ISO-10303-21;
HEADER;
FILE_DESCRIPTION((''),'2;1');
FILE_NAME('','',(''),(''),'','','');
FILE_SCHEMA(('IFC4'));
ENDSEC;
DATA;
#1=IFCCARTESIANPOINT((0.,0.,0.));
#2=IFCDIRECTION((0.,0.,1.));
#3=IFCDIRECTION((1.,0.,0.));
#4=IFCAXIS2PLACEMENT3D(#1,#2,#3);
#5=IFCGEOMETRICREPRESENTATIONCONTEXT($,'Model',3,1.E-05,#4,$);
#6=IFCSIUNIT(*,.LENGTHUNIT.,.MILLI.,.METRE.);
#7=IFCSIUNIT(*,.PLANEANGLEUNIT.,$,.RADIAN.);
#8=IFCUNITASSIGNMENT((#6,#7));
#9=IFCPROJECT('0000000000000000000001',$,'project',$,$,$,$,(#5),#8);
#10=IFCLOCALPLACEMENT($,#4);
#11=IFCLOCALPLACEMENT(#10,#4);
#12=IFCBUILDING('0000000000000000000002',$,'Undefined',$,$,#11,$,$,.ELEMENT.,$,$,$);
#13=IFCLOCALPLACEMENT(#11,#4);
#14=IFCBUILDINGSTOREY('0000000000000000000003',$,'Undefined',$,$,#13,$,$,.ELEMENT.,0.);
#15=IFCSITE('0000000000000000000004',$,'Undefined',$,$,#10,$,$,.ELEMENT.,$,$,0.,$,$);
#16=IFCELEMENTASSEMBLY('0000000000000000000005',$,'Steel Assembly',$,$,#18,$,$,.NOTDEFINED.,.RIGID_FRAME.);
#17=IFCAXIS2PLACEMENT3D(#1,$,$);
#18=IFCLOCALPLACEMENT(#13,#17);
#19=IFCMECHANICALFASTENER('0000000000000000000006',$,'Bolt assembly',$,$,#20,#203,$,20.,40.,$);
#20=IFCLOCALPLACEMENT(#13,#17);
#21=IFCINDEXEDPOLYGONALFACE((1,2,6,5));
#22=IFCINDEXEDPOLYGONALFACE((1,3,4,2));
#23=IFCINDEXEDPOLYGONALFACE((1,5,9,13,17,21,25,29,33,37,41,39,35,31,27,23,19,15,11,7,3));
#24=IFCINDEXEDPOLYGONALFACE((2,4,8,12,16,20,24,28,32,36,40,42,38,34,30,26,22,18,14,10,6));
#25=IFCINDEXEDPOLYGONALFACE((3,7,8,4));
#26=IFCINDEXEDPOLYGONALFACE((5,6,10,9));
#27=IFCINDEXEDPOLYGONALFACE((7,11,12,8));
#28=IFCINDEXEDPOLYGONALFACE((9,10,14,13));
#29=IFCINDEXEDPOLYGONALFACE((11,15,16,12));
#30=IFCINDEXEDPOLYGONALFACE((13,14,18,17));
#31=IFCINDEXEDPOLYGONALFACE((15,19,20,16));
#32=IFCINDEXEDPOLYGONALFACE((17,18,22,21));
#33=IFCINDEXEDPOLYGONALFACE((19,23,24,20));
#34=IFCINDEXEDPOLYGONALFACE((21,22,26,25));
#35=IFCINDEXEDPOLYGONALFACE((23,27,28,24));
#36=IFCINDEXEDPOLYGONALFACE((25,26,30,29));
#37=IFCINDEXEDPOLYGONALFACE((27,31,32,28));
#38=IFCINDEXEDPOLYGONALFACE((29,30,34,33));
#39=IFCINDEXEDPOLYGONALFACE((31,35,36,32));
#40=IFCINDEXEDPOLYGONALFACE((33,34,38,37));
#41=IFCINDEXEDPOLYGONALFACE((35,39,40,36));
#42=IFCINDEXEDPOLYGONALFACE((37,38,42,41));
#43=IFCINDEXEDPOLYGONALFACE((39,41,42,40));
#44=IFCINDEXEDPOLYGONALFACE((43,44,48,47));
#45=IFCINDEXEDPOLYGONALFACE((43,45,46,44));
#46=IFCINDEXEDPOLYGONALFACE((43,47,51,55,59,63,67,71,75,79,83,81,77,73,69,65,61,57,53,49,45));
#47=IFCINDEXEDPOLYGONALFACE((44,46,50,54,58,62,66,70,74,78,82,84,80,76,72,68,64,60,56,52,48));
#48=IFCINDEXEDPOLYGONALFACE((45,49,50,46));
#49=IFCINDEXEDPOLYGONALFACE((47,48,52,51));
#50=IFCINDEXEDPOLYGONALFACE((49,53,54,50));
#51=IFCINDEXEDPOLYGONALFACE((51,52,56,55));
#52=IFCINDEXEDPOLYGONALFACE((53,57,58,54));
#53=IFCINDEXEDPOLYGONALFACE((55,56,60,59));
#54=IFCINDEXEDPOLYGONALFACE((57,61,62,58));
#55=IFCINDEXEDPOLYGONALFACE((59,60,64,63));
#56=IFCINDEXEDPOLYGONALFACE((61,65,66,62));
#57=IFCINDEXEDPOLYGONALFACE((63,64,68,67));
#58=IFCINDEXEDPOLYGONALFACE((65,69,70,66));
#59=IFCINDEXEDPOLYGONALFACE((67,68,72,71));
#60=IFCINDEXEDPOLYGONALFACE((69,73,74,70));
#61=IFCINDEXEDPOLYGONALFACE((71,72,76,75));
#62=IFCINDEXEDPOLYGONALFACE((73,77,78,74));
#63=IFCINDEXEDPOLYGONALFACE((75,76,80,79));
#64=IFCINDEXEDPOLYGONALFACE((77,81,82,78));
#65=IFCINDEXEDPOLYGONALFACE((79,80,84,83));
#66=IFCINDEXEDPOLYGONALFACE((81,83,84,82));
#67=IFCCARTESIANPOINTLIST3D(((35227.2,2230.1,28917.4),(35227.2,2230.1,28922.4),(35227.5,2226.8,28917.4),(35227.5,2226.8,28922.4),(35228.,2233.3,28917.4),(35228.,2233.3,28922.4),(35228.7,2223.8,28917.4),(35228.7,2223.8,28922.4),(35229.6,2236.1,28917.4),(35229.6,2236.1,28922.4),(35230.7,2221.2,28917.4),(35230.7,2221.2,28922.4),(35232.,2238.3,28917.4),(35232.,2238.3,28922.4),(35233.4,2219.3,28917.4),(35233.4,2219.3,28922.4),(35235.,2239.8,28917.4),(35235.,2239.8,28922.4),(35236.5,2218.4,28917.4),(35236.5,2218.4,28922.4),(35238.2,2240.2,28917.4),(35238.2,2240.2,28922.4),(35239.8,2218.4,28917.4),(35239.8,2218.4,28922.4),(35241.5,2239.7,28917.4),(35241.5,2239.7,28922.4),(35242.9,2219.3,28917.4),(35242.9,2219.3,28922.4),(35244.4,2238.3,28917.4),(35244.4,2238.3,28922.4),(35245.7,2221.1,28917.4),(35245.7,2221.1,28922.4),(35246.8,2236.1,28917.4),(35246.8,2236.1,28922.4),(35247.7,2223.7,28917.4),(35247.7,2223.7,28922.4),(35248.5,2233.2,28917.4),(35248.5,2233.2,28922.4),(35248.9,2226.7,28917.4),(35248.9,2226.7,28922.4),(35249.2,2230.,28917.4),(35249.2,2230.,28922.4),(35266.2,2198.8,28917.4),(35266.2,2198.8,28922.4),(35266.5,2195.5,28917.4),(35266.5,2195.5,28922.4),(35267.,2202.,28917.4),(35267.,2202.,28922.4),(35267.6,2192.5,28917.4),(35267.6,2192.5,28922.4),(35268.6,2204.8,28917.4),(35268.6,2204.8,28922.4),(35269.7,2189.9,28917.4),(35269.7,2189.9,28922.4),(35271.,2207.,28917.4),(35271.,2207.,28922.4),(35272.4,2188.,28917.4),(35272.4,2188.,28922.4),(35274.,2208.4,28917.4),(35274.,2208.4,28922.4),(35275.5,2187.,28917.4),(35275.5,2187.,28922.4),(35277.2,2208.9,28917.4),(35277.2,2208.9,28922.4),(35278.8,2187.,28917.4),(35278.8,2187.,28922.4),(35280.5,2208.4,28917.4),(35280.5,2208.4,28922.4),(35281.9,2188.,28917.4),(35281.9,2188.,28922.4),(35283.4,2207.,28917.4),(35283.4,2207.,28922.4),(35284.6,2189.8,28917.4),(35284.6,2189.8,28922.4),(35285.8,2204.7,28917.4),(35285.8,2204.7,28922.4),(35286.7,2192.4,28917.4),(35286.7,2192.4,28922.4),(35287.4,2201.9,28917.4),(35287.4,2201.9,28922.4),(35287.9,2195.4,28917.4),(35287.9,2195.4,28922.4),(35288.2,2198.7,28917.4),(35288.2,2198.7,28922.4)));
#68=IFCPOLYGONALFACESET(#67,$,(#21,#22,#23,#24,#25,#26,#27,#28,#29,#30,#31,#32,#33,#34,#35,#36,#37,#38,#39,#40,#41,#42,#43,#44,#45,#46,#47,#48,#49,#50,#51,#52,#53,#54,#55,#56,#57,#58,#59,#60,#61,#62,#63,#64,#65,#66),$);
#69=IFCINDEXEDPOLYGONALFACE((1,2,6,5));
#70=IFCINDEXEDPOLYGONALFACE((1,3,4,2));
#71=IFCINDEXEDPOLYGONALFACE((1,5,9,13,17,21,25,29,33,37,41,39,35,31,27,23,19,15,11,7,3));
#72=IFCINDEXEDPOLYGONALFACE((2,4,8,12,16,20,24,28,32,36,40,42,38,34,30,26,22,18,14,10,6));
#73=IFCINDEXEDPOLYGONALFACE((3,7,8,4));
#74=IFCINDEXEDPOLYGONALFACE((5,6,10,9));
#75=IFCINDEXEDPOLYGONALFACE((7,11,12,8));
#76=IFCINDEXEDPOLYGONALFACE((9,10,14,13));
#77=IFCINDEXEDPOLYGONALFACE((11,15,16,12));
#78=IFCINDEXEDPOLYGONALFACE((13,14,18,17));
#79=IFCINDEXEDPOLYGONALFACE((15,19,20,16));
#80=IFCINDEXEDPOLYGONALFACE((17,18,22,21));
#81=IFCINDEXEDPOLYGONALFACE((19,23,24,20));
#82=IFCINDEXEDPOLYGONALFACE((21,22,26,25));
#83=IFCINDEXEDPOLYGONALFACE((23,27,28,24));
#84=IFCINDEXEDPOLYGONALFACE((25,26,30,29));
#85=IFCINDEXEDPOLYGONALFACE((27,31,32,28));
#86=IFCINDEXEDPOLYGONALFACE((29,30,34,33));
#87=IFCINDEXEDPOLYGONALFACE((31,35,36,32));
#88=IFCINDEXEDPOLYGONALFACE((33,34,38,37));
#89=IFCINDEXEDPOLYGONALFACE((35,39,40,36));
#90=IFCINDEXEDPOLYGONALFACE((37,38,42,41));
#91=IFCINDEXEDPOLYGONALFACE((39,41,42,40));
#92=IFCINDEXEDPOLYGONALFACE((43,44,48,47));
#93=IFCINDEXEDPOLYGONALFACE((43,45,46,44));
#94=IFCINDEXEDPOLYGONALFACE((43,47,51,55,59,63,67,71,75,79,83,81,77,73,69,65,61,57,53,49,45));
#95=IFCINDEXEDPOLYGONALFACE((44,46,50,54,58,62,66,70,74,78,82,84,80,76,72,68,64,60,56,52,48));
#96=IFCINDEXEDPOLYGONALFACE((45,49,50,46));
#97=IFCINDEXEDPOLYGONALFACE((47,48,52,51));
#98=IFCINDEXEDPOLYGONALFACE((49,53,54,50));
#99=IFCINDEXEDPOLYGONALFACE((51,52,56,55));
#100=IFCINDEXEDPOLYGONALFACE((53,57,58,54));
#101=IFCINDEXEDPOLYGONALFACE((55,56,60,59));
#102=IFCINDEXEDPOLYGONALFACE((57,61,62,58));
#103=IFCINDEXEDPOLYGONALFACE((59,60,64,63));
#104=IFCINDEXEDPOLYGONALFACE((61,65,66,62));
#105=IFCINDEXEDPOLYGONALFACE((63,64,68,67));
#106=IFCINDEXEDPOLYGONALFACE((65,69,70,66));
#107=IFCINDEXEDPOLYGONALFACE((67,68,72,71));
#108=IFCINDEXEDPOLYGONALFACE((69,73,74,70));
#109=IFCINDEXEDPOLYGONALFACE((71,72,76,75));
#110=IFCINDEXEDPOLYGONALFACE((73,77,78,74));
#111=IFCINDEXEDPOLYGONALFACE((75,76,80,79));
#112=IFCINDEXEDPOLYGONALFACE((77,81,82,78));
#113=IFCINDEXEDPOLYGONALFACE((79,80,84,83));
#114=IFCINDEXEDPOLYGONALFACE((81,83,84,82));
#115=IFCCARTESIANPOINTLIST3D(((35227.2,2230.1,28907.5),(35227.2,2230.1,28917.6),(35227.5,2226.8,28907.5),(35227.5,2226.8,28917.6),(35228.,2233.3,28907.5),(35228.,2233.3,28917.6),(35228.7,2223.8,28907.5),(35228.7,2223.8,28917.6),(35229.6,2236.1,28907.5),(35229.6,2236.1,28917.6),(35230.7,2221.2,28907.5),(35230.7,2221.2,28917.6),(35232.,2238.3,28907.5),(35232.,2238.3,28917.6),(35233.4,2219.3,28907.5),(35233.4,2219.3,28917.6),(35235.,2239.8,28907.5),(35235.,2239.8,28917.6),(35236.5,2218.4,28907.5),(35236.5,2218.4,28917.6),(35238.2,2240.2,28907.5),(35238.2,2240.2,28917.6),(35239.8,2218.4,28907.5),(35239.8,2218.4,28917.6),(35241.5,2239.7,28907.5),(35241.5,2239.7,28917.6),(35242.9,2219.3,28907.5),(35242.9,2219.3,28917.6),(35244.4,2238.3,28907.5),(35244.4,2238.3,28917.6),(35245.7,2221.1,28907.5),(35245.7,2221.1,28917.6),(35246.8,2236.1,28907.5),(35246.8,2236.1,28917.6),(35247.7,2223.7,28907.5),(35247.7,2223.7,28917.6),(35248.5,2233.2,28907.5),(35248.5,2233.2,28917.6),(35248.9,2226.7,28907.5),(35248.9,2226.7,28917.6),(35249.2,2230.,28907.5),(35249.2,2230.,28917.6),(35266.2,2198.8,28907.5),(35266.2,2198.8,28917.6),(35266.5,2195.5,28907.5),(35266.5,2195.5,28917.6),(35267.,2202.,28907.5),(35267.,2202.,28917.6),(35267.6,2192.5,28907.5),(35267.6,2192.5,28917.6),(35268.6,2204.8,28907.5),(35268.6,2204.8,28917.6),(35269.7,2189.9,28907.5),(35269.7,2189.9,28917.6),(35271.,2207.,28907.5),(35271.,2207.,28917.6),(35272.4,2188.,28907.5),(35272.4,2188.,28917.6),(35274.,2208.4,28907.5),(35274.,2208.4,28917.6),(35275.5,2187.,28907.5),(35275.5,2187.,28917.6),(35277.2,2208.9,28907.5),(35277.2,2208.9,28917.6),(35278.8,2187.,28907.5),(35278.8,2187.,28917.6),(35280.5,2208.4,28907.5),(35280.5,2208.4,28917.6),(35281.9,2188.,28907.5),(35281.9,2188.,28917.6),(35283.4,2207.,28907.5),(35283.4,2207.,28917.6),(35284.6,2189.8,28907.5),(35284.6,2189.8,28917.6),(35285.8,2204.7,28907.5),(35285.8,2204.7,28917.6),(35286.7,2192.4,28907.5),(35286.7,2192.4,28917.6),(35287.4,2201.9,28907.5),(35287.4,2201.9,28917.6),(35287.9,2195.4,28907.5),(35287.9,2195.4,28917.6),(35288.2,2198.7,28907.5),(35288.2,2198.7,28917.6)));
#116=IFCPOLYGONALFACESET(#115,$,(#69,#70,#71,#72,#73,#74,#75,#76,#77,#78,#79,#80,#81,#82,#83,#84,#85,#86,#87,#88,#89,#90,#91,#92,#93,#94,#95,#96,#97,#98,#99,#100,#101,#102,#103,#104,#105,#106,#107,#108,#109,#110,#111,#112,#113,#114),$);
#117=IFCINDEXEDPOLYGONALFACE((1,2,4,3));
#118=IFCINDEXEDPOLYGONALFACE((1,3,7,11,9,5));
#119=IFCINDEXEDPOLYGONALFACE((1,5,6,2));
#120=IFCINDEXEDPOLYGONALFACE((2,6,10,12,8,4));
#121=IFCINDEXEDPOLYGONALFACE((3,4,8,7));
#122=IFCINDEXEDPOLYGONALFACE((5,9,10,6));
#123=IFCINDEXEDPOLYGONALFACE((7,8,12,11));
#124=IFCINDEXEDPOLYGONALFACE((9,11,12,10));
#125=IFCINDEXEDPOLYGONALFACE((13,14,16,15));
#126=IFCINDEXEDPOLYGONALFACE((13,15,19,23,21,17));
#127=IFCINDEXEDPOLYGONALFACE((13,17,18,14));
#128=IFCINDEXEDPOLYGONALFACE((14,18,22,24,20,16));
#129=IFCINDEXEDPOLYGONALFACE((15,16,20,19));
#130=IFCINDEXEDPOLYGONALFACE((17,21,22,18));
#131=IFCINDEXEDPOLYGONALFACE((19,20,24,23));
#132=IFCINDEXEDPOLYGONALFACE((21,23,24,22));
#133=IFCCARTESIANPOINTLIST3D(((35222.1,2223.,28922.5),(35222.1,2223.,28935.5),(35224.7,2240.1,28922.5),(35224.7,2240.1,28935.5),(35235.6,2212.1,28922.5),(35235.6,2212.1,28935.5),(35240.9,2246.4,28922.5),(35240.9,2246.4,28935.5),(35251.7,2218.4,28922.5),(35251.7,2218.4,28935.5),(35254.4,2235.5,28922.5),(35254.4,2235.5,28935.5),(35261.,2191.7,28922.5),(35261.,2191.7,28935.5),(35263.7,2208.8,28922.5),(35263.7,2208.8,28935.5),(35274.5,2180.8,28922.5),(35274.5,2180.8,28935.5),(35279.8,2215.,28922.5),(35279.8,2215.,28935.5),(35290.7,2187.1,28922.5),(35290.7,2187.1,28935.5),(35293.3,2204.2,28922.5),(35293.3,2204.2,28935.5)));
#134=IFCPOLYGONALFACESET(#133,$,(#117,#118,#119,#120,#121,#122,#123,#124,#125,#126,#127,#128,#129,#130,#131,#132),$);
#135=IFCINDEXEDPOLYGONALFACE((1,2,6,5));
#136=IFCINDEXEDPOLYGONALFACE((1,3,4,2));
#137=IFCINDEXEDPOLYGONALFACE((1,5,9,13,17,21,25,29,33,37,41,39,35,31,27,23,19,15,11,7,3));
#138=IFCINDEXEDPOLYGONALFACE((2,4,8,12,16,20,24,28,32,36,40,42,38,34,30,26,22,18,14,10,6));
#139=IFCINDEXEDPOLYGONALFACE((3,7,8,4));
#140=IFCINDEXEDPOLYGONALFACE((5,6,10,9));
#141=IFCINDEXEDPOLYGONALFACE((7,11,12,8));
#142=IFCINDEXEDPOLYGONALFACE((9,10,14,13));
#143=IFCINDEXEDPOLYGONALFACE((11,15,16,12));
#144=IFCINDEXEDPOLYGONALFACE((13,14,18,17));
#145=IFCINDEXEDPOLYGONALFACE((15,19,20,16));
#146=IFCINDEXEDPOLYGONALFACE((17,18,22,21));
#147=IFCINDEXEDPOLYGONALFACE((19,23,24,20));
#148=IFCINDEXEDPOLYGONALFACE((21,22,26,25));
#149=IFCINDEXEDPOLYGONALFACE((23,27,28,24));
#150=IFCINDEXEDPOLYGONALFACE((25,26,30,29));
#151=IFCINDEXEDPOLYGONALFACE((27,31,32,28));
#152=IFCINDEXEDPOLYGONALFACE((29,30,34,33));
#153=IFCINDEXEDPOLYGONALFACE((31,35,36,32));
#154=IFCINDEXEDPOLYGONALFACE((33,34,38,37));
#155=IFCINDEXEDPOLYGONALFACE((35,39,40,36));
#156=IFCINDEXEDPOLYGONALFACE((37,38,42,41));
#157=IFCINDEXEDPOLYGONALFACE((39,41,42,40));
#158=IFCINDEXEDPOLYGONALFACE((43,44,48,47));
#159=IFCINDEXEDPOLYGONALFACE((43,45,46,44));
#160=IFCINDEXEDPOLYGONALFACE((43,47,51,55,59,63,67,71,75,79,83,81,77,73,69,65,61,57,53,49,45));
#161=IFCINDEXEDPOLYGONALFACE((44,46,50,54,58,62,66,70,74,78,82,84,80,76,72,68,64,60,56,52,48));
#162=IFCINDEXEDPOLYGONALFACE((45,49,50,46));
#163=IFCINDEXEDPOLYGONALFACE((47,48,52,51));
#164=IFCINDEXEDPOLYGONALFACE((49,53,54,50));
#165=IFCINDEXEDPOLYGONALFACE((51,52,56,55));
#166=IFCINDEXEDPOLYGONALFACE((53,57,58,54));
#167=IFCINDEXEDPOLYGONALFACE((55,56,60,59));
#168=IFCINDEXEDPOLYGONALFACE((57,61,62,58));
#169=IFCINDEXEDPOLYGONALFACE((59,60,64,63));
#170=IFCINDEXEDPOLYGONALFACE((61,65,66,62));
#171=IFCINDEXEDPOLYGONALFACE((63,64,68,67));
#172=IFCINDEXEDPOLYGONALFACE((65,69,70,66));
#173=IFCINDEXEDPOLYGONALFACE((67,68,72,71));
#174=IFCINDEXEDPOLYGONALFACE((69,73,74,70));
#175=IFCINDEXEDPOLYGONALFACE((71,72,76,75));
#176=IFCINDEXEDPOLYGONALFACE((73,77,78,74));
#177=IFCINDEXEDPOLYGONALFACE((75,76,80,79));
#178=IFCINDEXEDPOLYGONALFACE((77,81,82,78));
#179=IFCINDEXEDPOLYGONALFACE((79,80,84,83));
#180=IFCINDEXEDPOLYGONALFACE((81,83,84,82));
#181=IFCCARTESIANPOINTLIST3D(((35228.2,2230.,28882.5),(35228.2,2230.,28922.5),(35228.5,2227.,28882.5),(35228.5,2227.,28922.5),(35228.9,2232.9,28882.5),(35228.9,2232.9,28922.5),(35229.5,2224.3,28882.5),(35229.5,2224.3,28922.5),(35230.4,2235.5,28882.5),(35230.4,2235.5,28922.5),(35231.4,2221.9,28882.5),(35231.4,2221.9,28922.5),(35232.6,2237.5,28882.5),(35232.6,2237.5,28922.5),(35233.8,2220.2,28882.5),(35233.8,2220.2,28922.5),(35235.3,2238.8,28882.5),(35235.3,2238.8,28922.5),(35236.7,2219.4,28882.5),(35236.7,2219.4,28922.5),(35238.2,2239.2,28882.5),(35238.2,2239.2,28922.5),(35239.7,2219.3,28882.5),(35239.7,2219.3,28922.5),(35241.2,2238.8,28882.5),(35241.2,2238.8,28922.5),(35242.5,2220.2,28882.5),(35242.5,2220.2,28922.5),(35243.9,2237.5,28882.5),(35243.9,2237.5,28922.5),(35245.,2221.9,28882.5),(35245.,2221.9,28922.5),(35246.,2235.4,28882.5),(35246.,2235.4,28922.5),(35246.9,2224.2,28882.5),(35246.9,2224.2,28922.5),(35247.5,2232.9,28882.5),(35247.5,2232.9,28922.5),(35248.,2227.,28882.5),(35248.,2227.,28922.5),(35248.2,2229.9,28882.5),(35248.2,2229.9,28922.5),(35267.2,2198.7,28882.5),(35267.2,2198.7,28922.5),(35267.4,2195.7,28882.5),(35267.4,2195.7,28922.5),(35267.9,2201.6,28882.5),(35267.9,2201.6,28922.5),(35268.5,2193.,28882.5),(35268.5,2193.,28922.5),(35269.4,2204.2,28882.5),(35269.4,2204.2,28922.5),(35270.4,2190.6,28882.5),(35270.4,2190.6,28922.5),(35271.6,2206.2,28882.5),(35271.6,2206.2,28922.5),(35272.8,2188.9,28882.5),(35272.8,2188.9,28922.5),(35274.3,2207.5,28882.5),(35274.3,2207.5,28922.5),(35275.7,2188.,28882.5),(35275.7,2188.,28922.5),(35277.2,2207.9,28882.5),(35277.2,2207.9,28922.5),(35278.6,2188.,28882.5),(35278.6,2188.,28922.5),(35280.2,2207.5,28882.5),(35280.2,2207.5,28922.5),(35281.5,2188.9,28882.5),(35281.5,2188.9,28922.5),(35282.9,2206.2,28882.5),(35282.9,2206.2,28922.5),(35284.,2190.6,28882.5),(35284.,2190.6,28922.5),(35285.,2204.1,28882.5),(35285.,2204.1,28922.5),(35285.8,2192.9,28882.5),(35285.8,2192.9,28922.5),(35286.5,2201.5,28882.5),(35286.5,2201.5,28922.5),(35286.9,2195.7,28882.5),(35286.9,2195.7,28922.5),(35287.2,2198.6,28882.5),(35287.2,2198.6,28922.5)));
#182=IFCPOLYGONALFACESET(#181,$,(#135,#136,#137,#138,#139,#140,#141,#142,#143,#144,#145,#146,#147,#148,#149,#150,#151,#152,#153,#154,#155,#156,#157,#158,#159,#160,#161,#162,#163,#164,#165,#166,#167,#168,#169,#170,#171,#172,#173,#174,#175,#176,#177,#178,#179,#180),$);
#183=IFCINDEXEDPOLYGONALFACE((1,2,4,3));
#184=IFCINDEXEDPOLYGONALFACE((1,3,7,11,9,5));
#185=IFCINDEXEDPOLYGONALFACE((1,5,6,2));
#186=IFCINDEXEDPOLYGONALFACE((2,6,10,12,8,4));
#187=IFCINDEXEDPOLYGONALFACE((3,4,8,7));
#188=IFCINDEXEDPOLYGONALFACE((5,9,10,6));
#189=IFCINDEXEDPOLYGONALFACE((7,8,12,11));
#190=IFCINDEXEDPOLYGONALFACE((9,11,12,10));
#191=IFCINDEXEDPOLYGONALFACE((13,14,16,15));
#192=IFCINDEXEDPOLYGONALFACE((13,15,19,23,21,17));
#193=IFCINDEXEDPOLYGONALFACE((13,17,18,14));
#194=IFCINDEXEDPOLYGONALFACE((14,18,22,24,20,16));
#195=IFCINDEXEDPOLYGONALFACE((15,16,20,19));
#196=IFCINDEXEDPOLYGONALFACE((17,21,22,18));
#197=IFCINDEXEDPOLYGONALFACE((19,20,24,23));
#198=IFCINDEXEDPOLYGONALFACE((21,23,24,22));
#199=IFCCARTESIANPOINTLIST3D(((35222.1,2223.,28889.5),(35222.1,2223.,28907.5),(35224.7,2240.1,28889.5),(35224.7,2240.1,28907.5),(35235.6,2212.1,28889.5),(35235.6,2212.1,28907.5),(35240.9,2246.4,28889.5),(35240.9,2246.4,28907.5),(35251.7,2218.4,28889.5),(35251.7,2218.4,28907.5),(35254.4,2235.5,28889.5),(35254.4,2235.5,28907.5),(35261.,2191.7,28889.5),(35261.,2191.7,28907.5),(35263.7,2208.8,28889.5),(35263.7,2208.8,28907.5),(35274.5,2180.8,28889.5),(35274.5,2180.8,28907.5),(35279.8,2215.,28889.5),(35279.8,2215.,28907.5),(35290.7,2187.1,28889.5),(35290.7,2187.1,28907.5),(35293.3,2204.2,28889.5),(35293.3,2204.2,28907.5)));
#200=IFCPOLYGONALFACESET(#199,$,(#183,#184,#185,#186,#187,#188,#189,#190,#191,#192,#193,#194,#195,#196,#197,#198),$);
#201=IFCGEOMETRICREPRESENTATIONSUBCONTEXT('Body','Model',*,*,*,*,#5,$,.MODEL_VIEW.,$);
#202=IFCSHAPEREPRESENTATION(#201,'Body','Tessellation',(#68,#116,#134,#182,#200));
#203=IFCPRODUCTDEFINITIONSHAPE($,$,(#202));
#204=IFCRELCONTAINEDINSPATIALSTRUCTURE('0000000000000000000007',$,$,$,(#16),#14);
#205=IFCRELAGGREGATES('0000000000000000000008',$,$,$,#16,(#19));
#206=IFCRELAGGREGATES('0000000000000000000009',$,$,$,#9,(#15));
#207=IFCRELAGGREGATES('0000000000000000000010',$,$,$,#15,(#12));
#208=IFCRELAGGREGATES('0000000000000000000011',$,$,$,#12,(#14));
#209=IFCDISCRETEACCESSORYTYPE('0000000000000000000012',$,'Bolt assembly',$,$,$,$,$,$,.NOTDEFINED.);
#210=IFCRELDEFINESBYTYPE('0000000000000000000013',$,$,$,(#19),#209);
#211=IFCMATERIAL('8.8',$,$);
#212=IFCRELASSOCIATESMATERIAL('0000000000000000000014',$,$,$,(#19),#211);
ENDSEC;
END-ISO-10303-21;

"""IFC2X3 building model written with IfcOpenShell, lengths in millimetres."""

from ifc_helpers import new_model, si_unit, frame, origin_with_axes, origin_2d_with_axis, place, context, subcontext, project, spatial, polyline, circle, outline, extrude, source, transform, mapped, material, type_object, element, aggregate, save


model = new_model("IFC2X3")

# Units and contexts
model_context = context("Model", 3, precision=1e-05, world=origin_with_axes())
body_context = subcontext(model_context, "Body", "Model", "MODEL_VIEW")
ifc_project = project(units=[si_unit("LENGTHUNIT", "METRE", prefix="MILLI"), si_unit("PLANEANGLEUNIT", "RADIAN")], contexts=[model_context])

# Site, building, storey
site_placement = place(None, origin_with_axes())
site = spatial("IfcSite", under=ifc_project, at=site_placement, Name="Undefined", CompositionType="ELEMENT", RefElevation=0.0)
building_placement = place(site_placement, origin_with_axes())
building = spatial("IfcBuilding", under=site, at=building_placement, Name="Undefined", CompositionType="ELEMENT")
storey_placement = place(building_placement, origin_with_axes())
storey = spatial("IfcBuildingStorey", under=building, at=storey_placement, Name="Undefined", CompositionType="ELEMENT", Elevation=0.0)

# Element assembly
assembly_1_placement = place(storey_placement, origin_with_axes())
assembly_1 = element("IfcElementAssembly", 1, at=assembly_1_placement, inside=storey, Name="Steel Assembly", AssemblyPlace="NOTDEFINED", PredefinedType="RIGID_FRAME")

# Shared definitions
discrete_accessory_type_1 = type_object("IfcDiscreteAccessoryType", Name="Bolt assembly")
ifc_material_1 = material(Name="8.8")

# Mechanical fastener
shared_shape_1 = source(origin_with_axes(), body_context, "Body", "SweptSolid", [
    extrude(circle(Radius=11.0, at=origin_2d_with_axis()), frame((0.0, 0.1, 0.0), z_axis=(0.0, 1.0, 0.0), x_axis=(1.0, 0.0, 0.0)), (0.0, 0.0, 1.0), 5.0),
    extrude(circle(Radius=11.0, at=origin_2d_with_axis()), frame((0.0, 4.9, 0.0), z_axis=(0.0, 1.0, 0.0), x_axis=(1.0, 0.0, 0.0)), (0.0, 0.0, 1.0), 10.1),
    extrude(outline(polyline([(17.3, 0.0), (8.7, 15.0), (-8.7, 15.0), (-17.3, 0.0), (-8.7, -15.0), (8.7, -15.0), (17.3, 0.0)])), frame((0.0, -13.0, 0.0), z_axis=(0.0, 1.0, 0.0), x_axis=(1.0, 0.0, 0.0)), (0.0, 0.0, 1.0), 13.0),
    extrude(circle(Radius=10.0, at=origin_2d_with_axis()), frame((0.0, 0.0, 0.0), z_axis=(0.0, 1.0, 0.0), x_axis=(1.0, 0.0, 0.0)), (0.0, 0.0, 1.0), 40.0),
    extrude(outline(polyline([(17.3, 0.0), (8.7, 15.0), (-8.7, 15.0), (-17.3, 0.0), (-8.7, -15.0), (8.7, -15.0), (17.3, 0.0)])), frame((0.0, 15.0, 0.0), z_axis=(0.0, 1.0, 0.0), x_axis=(1.0, 0.0, 0.0)), (0.0, 0.0, 1.0), 18.0),
])
mechanical_fastener_1_placement = place(assembly_1_placement, frame((35277.2, 2197.9, 28922.5), z_axis=(-0.6263, -0.779582, 0.0), x_axis=(-0.779582, 0.6263, 0.0)))
mechanical_fastener_1 = element("IfcMechanicalFastener", 2, at=mechanical_fastener_1_placement, type_object=discrete_accessory_type_1, material=ifc_material_1, Name="Bolt assembly", NominalDiameter=20.0, NominalLength=40.0, context=body_context, shape_type="MappedRepresentation", body=[
    mapped(shared_shape_1, transform((0.0, 0.0, 0.0))),
    mapped(shared_shape_1, transform((50.0, 0.0, 0.0))),
])
aggregate(assembly_1, [mechanical_fastener_1])

save(model, "model.ifc")
